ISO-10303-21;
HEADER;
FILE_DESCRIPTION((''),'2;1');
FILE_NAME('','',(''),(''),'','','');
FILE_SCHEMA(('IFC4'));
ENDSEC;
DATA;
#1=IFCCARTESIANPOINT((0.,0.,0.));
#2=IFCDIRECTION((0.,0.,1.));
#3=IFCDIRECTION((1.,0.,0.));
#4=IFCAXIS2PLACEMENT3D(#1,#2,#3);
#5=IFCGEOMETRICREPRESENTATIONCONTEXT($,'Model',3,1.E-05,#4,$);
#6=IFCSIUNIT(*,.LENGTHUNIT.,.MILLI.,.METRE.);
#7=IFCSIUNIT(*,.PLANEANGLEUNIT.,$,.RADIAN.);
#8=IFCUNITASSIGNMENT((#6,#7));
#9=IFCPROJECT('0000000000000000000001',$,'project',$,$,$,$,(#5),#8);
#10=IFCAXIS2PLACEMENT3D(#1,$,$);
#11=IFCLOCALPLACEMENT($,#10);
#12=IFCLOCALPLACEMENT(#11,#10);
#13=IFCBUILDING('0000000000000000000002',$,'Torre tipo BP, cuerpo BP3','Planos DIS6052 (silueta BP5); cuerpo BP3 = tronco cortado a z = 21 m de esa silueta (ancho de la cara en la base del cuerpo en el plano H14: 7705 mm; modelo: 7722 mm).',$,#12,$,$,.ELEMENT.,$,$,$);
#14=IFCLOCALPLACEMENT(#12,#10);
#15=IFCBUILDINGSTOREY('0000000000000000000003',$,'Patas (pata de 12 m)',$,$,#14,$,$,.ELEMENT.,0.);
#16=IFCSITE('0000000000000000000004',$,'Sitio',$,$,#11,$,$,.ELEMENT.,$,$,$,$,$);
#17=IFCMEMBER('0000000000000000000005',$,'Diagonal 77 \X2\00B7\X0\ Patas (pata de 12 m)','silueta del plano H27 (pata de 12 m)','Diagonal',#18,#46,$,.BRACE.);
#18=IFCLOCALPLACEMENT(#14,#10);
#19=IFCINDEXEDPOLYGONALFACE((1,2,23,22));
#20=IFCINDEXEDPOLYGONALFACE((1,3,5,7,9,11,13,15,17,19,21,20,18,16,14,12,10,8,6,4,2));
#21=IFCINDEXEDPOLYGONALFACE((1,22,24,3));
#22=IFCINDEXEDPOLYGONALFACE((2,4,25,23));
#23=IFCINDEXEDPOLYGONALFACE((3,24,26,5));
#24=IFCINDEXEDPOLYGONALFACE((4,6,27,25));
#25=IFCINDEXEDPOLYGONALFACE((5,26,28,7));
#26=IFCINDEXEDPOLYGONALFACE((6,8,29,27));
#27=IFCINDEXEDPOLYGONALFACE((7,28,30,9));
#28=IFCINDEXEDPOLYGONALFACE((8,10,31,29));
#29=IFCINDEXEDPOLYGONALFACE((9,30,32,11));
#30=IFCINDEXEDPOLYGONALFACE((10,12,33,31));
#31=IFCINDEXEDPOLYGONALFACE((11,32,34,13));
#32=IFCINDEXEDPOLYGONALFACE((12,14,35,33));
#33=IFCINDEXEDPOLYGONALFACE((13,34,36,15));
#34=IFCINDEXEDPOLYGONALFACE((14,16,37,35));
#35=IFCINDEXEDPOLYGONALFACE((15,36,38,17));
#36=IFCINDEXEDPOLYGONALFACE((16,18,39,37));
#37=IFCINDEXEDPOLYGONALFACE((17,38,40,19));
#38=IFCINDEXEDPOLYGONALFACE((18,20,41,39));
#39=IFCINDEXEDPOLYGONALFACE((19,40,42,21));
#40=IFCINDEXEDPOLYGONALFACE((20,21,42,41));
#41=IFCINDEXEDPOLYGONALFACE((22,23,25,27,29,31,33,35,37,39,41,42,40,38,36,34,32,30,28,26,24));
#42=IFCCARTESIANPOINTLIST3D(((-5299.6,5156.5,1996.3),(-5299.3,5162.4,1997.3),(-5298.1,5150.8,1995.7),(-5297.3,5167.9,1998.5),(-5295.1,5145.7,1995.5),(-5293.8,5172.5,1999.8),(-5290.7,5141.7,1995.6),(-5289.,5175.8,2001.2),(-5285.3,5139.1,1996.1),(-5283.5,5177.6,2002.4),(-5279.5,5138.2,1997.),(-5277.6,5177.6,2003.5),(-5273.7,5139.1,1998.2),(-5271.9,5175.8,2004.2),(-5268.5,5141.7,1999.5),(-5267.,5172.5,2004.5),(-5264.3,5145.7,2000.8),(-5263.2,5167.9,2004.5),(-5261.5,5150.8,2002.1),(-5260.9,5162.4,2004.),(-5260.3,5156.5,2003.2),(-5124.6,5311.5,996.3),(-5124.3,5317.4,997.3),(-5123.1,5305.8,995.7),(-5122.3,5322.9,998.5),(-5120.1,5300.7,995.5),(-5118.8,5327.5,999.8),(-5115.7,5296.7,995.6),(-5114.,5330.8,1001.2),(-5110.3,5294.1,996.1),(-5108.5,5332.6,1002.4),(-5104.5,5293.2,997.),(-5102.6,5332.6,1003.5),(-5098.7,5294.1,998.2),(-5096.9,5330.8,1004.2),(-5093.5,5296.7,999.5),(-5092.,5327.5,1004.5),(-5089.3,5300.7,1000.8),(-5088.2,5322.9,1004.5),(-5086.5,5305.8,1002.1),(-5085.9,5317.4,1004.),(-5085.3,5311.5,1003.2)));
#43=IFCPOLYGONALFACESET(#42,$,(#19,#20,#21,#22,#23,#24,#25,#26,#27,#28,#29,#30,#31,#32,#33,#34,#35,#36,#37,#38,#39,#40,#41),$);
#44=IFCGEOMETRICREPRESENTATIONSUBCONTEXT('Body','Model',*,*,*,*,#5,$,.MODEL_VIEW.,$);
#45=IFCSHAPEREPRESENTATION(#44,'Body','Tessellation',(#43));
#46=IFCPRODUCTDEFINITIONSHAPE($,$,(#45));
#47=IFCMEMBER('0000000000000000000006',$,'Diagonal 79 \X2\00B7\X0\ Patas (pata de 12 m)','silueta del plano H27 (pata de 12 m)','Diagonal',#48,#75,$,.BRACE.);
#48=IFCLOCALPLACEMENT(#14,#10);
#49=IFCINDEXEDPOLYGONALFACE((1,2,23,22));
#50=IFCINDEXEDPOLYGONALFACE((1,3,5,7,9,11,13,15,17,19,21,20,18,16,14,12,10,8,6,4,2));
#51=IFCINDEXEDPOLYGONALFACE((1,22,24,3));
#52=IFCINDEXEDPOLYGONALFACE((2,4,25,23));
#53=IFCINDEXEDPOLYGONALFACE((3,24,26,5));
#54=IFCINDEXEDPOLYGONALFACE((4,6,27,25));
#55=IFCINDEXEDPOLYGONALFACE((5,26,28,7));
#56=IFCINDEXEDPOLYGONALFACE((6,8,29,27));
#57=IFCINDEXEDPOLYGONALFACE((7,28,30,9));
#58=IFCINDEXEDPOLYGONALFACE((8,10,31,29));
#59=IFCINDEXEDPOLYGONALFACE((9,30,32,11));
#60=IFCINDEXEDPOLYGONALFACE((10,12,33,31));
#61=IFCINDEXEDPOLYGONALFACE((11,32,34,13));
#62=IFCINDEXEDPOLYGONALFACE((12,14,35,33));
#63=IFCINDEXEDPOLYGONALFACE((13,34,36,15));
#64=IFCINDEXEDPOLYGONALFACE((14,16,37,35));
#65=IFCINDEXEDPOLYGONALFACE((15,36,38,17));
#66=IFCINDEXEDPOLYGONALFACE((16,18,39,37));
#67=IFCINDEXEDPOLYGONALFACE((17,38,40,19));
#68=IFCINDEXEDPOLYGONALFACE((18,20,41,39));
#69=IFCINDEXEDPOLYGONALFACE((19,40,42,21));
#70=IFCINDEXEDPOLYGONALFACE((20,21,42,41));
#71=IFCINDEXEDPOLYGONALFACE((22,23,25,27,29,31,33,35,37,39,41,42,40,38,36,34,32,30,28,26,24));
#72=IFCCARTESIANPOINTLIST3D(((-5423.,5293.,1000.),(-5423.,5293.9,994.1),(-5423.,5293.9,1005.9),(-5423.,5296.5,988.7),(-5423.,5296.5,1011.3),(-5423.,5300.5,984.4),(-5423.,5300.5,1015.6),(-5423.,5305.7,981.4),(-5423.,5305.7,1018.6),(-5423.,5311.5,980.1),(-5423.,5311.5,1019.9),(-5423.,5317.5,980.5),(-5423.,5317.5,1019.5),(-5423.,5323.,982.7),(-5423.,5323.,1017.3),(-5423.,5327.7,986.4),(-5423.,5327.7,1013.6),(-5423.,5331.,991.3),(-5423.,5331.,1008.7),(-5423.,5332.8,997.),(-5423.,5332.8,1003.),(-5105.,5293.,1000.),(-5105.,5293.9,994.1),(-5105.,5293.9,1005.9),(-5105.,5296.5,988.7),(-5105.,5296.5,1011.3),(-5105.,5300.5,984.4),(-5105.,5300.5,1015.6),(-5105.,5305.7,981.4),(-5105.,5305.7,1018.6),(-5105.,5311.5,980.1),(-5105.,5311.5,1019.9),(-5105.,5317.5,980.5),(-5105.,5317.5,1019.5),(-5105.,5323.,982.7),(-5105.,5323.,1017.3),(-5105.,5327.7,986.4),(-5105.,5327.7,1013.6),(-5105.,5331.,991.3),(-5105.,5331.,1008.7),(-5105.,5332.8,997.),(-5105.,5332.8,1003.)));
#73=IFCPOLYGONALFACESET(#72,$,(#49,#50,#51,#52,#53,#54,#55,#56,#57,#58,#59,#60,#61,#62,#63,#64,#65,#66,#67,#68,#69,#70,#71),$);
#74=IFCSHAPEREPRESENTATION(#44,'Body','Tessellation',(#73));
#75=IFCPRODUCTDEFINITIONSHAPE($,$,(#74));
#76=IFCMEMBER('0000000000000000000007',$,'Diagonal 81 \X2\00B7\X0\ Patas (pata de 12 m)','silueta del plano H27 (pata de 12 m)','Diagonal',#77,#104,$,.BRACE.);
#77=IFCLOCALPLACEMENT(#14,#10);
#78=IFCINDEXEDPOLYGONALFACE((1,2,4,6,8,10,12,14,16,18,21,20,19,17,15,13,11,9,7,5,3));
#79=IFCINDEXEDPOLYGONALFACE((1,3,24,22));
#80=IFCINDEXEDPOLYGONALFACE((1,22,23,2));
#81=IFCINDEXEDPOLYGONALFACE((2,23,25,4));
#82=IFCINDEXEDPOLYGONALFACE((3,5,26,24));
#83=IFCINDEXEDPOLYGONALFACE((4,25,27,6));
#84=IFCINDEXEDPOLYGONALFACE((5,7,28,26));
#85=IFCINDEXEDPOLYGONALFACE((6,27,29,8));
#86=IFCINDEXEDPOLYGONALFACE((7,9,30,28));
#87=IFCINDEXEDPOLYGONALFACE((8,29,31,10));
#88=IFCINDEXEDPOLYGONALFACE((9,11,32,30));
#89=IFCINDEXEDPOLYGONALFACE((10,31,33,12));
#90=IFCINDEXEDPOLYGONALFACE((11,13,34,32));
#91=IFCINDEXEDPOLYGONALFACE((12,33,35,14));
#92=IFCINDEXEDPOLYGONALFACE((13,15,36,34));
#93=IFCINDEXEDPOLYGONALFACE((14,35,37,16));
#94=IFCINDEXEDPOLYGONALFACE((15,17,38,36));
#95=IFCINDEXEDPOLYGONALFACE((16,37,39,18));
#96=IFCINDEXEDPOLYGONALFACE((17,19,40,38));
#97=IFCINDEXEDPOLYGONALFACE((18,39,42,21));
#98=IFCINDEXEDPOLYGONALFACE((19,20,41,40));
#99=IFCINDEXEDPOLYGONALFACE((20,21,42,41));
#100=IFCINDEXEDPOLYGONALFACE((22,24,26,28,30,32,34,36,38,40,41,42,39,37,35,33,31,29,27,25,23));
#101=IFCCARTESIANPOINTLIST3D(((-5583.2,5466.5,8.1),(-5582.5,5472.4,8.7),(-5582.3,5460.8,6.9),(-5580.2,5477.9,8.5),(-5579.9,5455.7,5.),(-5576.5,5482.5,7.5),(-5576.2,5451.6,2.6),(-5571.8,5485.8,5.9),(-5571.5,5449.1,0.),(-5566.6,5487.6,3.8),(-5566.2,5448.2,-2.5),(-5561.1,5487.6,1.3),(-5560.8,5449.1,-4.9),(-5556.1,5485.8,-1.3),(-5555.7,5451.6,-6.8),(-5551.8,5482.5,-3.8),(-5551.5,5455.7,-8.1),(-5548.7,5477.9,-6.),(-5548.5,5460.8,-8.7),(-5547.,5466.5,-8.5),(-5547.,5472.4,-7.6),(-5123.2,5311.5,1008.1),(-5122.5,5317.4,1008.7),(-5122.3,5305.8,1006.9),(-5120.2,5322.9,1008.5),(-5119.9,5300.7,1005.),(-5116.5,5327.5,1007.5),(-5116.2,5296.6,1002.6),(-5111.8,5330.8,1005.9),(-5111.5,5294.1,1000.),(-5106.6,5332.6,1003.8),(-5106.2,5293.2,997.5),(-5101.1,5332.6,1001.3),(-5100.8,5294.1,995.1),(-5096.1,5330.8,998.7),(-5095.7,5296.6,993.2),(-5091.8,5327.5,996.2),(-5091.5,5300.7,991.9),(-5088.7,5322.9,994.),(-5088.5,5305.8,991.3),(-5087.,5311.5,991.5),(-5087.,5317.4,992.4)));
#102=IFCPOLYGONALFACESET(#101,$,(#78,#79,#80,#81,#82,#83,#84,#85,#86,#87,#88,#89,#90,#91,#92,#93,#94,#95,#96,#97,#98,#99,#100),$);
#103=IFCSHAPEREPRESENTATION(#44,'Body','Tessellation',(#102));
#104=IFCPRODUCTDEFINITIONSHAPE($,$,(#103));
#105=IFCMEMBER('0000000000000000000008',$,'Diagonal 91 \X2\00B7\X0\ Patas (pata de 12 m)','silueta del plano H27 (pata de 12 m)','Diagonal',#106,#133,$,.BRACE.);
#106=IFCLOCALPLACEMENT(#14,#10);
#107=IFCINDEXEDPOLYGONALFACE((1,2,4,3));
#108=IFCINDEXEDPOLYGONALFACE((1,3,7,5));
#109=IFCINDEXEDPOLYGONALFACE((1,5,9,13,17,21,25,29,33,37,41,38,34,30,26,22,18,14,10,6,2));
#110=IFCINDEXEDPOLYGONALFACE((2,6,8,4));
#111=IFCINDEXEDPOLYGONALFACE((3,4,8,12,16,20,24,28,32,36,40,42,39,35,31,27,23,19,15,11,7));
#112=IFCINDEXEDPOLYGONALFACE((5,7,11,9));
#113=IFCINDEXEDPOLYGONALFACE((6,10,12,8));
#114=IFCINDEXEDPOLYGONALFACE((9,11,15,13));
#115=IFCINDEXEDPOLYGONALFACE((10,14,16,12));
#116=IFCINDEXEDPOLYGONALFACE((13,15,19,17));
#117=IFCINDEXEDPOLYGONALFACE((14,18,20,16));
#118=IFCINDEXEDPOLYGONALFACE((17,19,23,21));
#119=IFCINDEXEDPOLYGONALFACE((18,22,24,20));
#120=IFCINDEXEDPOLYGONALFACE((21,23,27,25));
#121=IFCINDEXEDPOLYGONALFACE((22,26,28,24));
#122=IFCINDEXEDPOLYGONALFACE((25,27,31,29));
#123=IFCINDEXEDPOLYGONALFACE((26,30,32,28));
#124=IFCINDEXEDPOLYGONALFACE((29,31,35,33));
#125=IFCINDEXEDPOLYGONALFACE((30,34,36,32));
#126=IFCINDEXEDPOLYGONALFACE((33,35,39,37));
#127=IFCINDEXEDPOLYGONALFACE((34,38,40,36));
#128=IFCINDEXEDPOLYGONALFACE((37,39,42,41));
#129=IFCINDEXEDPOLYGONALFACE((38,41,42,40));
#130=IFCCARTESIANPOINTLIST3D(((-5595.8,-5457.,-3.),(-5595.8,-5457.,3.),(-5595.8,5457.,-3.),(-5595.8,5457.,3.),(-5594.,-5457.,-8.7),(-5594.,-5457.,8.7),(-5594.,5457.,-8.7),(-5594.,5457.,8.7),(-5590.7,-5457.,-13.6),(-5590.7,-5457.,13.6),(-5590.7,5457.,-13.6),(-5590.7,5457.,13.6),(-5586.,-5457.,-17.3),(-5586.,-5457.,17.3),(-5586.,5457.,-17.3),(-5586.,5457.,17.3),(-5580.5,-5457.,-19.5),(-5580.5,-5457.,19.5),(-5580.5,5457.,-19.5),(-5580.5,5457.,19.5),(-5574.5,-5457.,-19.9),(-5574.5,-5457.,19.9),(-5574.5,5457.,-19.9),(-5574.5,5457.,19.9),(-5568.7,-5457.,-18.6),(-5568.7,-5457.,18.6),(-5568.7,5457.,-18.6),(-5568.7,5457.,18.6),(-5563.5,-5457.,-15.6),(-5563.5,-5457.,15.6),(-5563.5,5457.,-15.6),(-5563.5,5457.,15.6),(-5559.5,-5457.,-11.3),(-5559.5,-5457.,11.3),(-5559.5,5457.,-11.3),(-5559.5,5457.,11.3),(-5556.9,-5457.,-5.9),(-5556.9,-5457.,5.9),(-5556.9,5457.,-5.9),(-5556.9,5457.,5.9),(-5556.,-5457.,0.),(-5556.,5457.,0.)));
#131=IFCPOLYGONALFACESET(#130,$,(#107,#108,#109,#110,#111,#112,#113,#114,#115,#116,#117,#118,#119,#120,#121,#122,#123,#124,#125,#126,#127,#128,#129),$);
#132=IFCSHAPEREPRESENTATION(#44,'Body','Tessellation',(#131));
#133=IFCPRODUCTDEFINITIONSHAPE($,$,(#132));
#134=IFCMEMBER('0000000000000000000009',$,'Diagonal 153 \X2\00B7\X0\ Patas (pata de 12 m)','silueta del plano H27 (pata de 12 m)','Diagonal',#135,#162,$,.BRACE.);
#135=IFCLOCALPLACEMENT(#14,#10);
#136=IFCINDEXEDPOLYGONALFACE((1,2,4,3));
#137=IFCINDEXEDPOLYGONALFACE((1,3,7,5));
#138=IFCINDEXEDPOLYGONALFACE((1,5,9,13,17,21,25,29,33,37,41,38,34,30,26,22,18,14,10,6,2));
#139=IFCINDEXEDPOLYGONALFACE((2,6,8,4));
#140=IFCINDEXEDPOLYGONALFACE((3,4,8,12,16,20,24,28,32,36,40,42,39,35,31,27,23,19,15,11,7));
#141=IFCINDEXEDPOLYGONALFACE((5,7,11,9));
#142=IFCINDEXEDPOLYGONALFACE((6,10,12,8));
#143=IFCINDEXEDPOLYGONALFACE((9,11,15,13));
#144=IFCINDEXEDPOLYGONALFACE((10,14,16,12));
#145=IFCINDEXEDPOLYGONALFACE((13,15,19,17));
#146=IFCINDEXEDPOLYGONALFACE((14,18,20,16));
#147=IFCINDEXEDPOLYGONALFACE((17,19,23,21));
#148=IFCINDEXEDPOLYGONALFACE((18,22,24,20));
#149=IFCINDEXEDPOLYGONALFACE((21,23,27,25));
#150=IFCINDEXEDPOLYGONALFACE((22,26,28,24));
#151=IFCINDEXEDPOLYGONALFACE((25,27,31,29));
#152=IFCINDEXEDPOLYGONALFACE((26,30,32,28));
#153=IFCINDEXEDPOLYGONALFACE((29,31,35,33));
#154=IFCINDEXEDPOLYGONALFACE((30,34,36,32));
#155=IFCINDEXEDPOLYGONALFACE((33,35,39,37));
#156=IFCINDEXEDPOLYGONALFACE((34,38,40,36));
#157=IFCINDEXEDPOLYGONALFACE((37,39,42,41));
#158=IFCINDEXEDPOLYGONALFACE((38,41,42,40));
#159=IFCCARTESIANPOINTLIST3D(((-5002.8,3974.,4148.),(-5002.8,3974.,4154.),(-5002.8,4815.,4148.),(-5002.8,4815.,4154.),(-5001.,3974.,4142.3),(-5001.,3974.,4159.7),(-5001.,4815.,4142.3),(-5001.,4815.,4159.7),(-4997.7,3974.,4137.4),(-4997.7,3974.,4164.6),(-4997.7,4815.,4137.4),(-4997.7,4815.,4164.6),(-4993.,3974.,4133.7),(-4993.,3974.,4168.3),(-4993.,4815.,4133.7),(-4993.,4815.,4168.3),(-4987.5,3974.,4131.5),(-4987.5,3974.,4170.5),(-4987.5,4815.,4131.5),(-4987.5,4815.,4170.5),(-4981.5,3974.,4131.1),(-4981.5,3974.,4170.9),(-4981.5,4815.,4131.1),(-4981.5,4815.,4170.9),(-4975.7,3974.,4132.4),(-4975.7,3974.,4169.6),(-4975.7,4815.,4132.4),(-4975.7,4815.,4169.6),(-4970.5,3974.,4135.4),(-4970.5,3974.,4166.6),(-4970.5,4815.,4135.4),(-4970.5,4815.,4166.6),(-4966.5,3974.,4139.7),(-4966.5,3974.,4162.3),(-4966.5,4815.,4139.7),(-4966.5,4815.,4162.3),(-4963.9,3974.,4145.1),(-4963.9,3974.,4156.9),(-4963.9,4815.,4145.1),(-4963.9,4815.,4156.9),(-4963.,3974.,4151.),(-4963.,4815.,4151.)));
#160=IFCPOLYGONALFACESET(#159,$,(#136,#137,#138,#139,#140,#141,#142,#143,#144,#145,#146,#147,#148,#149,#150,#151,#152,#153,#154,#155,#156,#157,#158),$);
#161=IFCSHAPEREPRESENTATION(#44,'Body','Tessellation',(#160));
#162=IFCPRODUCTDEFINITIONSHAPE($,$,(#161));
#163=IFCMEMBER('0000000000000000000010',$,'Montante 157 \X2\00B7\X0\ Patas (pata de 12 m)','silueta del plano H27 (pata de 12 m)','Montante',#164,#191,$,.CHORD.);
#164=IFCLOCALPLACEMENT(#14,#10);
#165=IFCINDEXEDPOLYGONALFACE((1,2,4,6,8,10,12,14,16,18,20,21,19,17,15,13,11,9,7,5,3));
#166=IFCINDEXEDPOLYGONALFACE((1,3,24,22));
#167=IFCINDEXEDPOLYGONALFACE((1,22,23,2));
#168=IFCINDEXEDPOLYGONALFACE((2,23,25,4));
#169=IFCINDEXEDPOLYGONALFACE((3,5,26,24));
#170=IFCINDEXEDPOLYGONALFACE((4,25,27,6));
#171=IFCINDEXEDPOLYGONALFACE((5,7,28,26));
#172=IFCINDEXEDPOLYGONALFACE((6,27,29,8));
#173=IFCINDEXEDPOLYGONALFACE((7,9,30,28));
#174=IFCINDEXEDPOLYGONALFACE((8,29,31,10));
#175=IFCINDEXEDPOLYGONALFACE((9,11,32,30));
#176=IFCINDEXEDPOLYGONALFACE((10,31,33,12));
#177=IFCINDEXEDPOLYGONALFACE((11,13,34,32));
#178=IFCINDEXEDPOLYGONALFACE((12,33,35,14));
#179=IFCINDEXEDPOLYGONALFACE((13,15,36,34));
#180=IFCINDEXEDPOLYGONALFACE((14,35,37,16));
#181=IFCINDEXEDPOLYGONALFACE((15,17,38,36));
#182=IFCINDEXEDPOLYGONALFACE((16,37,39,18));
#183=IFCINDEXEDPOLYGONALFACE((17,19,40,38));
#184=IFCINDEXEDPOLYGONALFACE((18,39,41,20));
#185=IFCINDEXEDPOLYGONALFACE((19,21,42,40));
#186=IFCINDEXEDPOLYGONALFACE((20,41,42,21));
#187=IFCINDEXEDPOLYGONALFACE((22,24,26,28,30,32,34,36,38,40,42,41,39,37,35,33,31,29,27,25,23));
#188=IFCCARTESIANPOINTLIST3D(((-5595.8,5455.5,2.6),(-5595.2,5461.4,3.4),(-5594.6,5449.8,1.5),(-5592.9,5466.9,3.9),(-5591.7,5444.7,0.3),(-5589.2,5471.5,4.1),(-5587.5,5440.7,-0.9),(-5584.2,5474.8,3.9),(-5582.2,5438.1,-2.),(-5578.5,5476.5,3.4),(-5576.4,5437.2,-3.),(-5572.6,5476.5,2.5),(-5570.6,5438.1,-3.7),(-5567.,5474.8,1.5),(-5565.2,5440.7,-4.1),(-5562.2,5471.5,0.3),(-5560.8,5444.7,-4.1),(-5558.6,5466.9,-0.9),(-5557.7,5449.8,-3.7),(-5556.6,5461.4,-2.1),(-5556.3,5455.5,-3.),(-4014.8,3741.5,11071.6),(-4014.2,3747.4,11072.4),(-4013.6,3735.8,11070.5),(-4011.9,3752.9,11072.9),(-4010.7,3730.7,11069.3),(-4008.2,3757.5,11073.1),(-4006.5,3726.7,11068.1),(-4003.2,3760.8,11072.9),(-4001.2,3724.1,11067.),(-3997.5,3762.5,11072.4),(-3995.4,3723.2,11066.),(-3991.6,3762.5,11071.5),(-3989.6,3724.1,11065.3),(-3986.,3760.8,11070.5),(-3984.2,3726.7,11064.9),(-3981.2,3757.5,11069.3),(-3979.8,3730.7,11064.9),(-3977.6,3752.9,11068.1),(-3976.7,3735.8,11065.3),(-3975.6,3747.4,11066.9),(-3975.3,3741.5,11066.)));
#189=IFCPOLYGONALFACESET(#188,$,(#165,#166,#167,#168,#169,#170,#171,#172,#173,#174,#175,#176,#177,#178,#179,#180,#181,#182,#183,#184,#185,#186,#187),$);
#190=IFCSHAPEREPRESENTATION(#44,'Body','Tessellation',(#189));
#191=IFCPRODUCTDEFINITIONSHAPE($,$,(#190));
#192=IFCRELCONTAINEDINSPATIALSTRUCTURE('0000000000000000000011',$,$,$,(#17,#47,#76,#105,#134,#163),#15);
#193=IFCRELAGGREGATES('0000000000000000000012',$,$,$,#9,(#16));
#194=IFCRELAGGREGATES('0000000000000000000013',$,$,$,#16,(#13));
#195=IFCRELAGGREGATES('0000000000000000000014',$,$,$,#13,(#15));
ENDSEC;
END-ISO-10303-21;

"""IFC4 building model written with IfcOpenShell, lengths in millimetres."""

from ifc_helpers import new_model, si_unit, frame, origin, origin_with_axes, place, context, subcontext, project, spatial, circle, extrude, element, save


model = new_model("IFC4")

# Units and contexts
model_context = context("Model", 3, precision=1e-05, world=origin_with_axes())
body_context = subcontext(model_context, "Body", "Model", "MODEL_VIEW")
ifc_project = project(units=[si_unit("LENGTHUNIT", "METRE", prefix="MILLI"), si_unit("PLANEANGLEUNIT", "RADIAN")], contexts=[model_context])

# Site, building, storey
site_placement = place(None, origin())
site = spatial("IfcSite", under=ifc_project, at=site_placement, Name="Sitio", CompositionType="ELEMENT")
building_placement = place(site_placement, origin())
building = spatial("IfcBuilding", under=site, at=building_placement, Name="Torre tipo BP, cuerpo BP3", Description="Planos DIS6052 (silueta BP5); cuerpo BP3 = tronco cortado a z = 21 m de esa silueta (ancho de la cara en la base del cuerpo en el plano H14: 7705 mm; modelo: 7722 mm).", CompositionType="ELEMENT")
storey_placement = place(building_placement, origin())
storey = spatial("IfcBuildingStorey", under=building, at=storey_placement, Name="Patas (pata de 12 m)", CompositionType="ELEMENT", Elevation=0.0)

# Members
member_1_placement = place(storey_placement, frame((-5105.0, 5313.0, 1000.0), z_axis=(-0.170406, -0.150931, 0.973746), x_axis=(0.026017, -0.988544, -0.148671)))
element("IfcMember", 1, at=member_1_placement, inside=storey, Name="Diagonal 77 · Patas (pata de 12 m)", Description="silueta del plano H27 (pata de 12 m)", ObjectType="Diagonal", PredefinedType="BRACE", context=body_context, shape_type="SweptSolid", body=[
    extrude(circle(Radius=20.0), None, (0.0, 0.0, 1.0), 1027.0),
])
member_2_placement = place(storey_placement, frame((-5423.0, 5313.0, 1000.0), z_axis=(1.0, 0.0, 0.0), x_axis=(0.0, -1.0, 0.0)))
element("IfcMember", 2, at=member_2_placement, inside=storey, Name="Diagonal 79 · Patas (pata de 12 m)", Description="silueta del plano H27 (pata de 12 m)", ObjectType="Diagonal", PredefinedType="BRACE", context=body_context, shape_type="SweptSolid", body=[
    extrude(circle(Radius=20.0), None, (0.0, 0.0, 1.0), 318.0),
])
member_3_placement = place(storey_placement, frame((-5565.0, 5468.0, 0.0), z_axis=(0.413823, -0.13944, 0.899615), x_axis=(-0.058273, -0.99023, -0.12668)))
element("IfcMember", 3, at=member_3_placement, inside=storey, Name="Diagonal 81 · Patas (pata de 12 m)", Description="silueta del plano H27 (pata de 12 m)", ObjectType="Diagonal", PredefinedType="BRACE", context=body_context, shape_type="SweptSolid", body=[
    extrude(circle(Radius=20.0), None, (0.0, 0.0, 1.0), 1111.6),
])
member_4_placement = place(storey_placement, frame((-5576.0, 5457.0, 0.0), z_axis=(0.0, -1.0, 0.0), x_axis=(1.0, 0.0, 0.0)))
element("IfcMember", 4, at=member_4_placement, inside=storey, Name="Diagonal 91 · Patas (pata de 12 m)", Description="silueta del plano H27 (pata de 12 m)", ObjectType="Diagonal", PredefinedType="BRACE", context=body_context, shape_type="SweptSolid", body=[
    extrude(circle(Radius=20.0), None, (0.0, 0.0, 1.0), 10914.0),
])
member_5_placement = place(storey_placement, frame((-4983.0, 4815.0, 4151.0), z_axis=(0.0, -1.0, 0.0), x_axis=(1.0, 0.0, 0.0)))
element("IfcMember", 5, at=member_5_placement, inside=storey, Name="Diagonal 153 · Patas (pata de 12 m)", Description="silueta del plano H27 (pata de 12 m)", ObjectType="Diagonal", PredefinedType="BRACE", context=body_context, shape_type="SweptSolid", body=[
    extrude(circle(Radius=20.0), None, (0.0, 0.0, 1.0), 841.0),
])
member_6_placement = place(storey_placement, frame((-5576.0, 5457.0, 0.0), z_axis=(0.139764, -0.151521, 0.978523), x_axis=(-0.021425, -0.988454, -0.149999)))
element("IfcMember", 6, at=member_6_placement, inside=storey, Name="Montante 157 · Patas (pata de 12 m)", Description="silueta del plano H27 (pata de 12 m)", ObjectType="Montante", PredefinedType="CHORD", context=body_context, shape_type="SweptSolid", body=[
    extrude(circle(Radius=20.0), None, (0.0, 0.0, 1.0), 11311.9),
])

save(model, "model.ifc")
